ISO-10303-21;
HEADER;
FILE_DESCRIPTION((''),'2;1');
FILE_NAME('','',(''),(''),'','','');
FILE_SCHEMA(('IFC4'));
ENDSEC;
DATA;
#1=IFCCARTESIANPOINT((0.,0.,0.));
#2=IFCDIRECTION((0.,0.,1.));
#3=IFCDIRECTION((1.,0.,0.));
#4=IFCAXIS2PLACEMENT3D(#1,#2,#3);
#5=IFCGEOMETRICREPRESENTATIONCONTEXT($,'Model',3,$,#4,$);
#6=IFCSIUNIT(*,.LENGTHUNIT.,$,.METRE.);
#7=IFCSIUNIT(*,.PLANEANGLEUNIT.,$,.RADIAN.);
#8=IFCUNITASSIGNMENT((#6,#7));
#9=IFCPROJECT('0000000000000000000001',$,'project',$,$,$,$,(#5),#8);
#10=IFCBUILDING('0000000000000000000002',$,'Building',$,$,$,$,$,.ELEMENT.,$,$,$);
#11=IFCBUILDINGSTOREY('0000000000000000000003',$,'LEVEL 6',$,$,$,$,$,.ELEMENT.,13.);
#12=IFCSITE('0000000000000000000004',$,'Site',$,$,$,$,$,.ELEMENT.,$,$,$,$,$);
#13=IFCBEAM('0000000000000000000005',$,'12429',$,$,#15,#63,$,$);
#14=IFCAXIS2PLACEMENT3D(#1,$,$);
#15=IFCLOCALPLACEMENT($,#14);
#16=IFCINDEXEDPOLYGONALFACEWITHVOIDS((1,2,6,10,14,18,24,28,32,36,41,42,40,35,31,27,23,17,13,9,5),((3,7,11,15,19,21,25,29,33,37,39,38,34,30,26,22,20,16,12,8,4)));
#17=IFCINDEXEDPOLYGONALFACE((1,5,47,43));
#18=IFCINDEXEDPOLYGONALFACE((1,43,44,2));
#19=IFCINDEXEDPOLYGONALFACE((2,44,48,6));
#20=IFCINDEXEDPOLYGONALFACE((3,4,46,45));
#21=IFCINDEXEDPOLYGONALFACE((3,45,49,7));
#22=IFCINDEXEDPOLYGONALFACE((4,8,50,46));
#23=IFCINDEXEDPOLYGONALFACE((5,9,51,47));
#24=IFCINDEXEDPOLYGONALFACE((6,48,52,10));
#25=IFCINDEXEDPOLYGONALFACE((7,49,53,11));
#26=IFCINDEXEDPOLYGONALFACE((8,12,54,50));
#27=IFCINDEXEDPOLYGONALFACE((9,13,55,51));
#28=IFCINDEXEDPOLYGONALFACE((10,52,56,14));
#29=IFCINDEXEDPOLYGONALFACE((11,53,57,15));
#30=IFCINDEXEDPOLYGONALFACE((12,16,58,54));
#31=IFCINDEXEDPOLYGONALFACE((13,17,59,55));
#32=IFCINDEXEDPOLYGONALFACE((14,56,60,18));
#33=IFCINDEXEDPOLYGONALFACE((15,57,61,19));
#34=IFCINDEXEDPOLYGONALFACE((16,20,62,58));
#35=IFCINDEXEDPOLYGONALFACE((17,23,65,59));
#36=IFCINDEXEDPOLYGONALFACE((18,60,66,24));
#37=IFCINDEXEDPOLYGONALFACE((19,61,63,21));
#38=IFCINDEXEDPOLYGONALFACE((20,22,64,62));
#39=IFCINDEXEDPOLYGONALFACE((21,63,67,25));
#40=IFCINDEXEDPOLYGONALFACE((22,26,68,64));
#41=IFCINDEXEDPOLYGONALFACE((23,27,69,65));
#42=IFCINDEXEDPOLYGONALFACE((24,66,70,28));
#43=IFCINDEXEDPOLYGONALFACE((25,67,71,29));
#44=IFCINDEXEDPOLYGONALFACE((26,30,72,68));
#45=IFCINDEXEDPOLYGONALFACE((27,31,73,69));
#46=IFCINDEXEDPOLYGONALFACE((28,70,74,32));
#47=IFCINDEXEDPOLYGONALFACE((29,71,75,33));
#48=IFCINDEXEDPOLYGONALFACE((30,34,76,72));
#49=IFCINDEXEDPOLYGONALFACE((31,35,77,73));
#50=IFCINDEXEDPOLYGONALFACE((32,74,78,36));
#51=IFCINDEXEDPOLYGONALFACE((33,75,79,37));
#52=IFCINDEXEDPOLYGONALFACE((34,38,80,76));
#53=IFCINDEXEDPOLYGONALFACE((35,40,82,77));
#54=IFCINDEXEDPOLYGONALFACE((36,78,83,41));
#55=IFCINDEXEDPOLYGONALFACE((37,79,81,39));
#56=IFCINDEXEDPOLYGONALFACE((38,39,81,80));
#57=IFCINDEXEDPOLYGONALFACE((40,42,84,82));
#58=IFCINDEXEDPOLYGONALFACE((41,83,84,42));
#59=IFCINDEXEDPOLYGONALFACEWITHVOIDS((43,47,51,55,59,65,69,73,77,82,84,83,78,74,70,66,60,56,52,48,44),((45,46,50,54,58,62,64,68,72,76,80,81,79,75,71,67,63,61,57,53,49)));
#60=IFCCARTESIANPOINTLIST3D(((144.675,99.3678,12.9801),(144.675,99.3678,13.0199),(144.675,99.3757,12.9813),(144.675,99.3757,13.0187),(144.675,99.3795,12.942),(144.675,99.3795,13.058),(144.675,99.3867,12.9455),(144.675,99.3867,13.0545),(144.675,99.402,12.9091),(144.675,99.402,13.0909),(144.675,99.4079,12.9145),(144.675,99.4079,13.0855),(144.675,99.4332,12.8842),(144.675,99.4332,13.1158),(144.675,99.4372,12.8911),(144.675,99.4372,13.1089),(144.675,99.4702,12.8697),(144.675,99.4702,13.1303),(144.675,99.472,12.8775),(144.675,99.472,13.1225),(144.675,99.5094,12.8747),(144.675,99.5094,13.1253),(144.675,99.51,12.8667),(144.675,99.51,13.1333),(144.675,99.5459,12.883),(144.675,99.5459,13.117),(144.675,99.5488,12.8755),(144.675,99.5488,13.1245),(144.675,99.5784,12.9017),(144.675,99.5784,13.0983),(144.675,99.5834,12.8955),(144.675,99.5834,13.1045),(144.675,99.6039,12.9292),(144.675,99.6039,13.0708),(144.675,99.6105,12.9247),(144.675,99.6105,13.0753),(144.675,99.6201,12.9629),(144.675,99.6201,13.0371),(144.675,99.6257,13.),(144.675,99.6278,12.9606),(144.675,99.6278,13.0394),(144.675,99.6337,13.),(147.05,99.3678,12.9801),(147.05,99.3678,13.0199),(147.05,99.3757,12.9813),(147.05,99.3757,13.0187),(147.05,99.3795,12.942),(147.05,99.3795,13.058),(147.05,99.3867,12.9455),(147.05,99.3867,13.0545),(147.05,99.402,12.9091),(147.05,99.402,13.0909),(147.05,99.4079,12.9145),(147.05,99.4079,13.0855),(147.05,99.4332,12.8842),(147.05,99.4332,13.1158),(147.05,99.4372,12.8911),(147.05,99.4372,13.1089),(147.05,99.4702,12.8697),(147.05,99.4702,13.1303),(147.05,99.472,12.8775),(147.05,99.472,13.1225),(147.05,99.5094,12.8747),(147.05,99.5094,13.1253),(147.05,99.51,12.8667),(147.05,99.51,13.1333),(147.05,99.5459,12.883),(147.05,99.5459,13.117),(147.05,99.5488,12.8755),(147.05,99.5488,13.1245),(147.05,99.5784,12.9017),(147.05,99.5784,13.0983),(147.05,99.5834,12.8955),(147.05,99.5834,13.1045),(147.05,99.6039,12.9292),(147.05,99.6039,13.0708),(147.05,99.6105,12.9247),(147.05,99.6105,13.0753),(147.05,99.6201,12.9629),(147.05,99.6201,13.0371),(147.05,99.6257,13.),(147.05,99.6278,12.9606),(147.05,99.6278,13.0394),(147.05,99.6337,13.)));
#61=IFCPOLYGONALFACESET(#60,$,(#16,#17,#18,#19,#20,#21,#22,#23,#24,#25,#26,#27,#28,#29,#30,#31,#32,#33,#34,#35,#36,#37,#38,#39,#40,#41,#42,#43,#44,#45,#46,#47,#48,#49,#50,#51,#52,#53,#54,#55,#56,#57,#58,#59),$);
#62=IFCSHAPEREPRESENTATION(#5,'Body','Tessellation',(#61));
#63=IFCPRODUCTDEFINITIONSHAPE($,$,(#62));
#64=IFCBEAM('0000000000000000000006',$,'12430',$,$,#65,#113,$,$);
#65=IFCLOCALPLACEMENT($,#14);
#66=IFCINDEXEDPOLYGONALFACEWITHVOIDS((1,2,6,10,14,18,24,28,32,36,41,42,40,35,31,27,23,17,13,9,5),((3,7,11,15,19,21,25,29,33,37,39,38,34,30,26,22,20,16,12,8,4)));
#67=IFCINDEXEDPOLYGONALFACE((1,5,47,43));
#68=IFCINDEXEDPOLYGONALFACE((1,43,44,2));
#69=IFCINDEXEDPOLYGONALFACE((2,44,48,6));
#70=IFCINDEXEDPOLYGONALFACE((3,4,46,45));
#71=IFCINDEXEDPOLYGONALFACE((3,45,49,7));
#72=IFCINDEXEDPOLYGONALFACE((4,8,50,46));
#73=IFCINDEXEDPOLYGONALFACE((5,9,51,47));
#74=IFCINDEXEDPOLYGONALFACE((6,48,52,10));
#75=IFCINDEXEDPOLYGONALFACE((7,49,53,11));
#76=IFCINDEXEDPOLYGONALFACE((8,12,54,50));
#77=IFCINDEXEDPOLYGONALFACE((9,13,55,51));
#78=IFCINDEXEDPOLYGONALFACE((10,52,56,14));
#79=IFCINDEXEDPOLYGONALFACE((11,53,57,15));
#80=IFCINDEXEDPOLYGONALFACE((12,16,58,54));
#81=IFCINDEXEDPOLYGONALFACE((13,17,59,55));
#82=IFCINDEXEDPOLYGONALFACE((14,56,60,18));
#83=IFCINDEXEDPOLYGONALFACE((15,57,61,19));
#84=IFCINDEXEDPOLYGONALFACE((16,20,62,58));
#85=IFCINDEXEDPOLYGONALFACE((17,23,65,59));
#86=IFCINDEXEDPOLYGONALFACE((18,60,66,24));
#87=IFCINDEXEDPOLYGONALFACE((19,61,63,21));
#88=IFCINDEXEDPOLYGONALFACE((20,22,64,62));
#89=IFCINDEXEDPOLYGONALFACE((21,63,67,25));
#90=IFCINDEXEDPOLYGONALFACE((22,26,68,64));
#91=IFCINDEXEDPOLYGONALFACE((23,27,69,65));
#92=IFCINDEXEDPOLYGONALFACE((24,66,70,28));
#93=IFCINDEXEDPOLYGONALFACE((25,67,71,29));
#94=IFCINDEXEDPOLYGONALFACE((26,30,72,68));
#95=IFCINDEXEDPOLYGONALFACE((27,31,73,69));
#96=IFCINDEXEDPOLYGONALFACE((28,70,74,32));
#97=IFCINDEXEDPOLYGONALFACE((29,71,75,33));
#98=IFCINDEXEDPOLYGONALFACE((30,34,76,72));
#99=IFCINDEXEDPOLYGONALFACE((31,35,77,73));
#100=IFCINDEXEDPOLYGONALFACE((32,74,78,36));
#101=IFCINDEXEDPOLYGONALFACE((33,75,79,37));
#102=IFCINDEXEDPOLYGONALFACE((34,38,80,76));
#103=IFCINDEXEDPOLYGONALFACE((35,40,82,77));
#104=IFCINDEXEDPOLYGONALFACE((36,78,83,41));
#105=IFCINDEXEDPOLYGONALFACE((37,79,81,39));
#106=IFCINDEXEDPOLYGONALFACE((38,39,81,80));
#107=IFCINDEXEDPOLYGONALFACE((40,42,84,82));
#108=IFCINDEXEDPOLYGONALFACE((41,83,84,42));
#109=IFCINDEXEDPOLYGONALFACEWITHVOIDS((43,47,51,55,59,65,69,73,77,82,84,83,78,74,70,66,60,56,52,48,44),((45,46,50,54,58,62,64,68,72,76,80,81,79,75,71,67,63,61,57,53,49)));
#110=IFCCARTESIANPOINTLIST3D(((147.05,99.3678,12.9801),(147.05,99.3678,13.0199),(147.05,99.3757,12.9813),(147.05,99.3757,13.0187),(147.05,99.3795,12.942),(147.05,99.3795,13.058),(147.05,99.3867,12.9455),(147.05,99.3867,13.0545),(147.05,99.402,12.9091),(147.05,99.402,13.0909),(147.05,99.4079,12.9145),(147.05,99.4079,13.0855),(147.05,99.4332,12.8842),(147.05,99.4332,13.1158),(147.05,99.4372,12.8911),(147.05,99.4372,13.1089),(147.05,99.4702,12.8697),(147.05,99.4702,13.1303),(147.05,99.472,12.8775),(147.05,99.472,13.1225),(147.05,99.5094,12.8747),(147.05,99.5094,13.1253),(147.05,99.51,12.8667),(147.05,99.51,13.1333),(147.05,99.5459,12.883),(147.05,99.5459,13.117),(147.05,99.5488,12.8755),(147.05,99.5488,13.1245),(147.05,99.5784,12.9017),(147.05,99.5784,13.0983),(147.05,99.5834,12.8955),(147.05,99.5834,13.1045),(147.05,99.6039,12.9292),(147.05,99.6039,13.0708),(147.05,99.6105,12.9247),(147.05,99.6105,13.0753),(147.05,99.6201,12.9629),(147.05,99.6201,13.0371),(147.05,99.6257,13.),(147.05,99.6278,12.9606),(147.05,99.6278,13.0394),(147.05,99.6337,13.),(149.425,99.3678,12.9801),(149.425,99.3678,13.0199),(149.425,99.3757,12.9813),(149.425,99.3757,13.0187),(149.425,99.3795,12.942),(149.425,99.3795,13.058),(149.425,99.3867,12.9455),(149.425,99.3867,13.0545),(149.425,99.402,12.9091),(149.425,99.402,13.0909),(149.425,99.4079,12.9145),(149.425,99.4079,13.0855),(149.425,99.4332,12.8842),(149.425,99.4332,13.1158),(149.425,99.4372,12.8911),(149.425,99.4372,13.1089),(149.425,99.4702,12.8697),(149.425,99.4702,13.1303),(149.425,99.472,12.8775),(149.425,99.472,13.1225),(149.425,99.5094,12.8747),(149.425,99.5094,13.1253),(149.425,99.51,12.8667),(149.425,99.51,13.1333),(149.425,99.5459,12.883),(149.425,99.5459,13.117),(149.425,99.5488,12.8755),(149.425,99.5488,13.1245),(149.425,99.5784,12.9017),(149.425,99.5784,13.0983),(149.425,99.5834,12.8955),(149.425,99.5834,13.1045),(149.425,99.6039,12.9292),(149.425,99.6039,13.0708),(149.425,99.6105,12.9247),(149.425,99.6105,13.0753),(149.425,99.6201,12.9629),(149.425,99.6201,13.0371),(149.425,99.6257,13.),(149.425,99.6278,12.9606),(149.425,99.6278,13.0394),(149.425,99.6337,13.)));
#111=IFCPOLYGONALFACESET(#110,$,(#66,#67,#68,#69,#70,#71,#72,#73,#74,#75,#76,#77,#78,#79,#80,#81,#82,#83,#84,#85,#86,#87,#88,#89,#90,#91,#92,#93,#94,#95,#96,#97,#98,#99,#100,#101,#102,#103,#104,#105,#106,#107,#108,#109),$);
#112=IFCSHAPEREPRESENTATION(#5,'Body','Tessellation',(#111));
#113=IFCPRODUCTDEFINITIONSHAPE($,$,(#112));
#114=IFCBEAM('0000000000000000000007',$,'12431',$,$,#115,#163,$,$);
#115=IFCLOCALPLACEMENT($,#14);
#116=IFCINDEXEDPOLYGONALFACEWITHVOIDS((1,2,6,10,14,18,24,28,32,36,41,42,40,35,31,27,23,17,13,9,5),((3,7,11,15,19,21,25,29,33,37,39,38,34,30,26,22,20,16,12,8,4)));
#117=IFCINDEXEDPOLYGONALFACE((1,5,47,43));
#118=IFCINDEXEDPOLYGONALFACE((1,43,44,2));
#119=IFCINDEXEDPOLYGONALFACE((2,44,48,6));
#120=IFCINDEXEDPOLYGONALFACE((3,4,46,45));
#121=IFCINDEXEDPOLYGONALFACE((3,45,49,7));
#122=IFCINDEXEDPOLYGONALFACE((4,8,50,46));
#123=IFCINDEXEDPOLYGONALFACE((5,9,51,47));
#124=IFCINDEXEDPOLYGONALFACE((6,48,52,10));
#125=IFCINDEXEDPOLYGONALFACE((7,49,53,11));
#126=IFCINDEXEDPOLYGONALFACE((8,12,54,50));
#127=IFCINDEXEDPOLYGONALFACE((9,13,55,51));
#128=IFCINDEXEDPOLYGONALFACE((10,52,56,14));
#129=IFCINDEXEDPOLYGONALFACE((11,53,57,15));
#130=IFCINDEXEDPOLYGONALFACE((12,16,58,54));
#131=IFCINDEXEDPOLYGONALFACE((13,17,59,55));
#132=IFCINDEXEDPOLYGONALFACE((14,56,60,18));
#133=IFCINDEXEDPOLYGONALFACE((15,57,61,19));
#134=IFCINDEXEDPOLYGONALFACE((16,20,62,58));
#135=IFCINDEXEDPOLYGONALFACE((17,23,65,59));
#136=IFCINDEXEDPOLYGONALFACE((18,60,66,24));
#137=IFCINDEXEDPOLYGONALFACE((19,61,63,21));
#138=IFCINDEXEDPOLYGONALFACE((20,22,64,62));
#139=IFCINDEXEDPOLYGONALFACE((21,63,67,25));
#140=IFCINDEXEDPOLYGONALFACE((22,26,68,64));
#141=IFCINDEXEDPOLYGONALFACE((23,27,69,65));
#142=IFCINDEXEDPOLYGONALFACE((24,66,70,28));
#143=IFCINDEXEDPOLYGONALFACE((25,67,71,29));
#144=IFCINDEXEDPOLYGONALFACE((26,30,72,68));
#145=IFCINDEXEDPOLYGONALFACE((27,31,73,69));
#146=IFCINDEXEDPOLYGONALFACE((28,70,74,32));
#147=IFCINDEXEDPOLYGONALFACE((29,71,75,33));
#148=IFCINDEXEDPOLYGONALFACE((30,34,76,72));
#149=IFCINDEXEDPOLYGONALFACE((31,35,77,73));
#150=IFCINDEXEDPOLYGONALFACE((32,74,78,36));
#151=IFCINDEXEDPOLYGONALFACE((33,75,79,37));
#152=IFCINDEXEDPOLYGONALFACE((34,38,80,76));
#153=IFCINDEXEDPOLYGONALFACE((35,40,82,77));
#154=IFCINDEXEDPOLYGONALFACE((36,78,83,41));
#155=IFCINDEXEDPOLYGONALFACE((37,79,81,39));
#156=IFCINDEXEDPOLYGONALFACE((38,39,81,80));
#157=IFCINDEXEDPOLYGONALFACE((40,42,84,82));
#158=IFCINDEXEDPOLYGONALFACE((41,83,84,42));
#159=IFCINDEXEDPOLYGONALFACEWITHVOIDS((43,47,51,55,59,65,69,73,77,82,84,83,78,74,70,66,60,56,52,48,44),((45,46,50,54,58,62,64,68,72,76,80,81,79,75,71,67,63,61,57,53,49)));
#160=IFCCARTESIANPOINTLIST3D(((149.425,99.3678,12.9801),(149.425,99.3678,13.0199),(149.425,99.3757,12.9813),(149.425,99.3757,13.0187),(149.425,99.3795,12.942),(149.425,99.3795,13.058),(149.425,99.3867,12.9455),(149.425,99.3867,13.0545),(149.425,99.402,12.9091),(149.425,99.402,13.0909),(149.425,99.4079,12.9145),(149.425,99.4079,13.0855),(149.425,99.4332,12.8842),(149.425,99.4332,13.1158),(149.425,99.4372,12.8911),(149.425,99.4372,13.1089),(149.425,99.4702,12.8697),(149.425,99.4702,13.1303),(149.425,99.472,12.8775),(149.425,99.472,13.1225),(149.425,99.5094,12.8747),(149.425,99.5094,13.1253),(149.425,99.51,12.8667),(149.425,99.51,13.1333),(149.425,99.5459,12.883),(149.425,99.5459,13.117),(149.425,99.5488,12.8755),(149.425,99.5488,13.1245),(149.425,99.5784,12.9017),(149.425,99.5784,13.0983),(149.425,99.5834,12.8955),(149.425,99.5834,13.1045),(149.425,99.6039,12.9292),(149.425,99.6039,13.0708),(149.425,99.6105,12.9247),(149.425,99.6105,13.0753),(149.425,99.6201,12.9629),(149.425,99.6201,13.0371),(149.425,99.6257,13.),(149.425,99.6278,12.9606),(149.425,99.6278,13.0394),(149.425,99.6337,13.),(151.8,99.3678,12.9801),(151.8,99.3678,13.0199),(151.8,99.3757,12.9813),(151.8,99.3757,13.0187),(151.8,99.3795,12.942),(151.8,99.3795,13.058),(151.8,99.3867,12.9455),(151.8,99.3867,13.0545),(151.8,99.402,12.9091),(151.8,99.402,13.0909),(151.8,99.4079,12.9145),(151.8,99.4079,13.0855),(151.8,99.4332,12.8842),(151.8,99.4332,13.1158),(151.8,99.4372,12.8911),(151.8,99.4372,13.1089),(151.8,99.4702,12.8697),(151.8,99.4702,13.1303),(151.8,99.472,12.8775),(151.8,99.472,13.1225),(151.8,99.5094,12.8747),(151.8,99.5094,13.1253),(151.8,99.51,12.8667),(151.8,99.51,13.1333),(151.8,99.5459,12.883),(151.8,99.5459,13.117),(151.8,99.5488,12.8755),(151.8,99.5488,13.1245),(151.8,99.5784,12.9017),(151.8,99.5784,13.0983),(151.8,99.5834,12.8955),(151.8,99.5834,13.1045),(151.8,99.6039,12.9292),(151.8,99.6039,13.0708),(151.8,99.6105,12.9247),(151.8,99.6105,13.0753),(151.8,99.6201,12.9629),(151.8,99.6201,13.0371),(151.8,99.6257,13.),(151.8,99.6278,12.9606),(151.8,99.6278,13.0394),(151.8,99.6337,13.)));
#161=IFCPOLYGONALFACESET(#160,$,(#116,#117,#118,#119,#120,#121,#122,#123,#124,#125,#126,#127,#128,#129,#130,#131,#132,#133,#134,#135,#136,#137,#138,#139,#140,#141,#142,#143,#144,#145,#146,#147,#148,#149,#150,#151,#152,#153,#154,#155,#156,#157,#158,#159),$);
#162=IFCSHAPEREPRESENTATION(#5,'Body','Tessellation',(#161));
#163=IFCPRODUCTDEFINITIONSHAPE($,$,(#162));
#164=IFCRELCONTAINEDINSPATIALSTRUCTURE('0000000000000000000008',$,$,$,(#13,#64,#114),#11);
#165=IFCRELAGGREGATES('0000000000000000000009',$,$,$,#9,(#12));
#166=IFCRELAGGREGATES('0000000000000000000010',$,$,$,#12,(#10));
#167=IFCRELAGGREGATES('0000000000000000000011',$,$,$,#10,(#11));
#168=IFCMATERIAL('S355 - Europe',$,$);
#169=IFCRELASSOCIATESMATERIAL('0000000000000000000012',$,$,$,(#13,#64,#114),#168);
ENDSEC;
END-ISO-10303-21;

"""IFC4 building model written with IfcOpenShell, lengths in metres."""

from ifc_helpers import new_model, si_unit, frame, origin_with_axes, origin_2d_with_axis, place, context, project, spatial, hollow_circle, extrude, material, material_profile, profile_set, profile_usage, element, save


model = new_model("IFC4")

# Units and contexts
model_context = context("Model", 3, world=origin_with_axes())
ifc_project = project(units=[si_unit("LENGTHUNIT", "METRE"), si_unit("PLANEANGLEUNIT", "RADIAN")], contexts=[model_context])

# Site, building, storey
site = spatial("IfcSite", under=ifc_project, Name="Site", CompositionType="ELEMENT")
building = spatial("IfcBuilding", under=site, Name="Building", CompositionType="ELEMENT")
storey = spatial("IfcBuildingStorey", under=building, Name="LEVEL 6", CompositionType="ELEMENT", Elevation=13.0)

# Shared definitions
ifc_material = material(Name="S355 - Europe")

# Beams
ifc_material_profile_1 = material_profile(ifc_material, hollow_circle(Radius=0.1337, WallThickness=0.008, at=origin_2d_with_axis()))
ifc_profile_set_1 = profile_set([ifc_material_profile_1])
ifc_profile_usage_1 = profile_usage(ifc_profile_set_1, cardinal=10)
beam_1_placement = place(None, frame((144.675, 99.5, 13.0), z_axis=(1.0, 0.0, 0.0), x_axis=(0.0, 1.0, 0.0)))
element("IfcBeam", 1, at=beam_1_placement, inside=storey, material=ifc_profile_usage_1, Name="12429", context=model_context, shape_type="SweptSolid", body=[
    extrude(hollow_circle(Radius=0.1337, WallThickness=0.008, at=origin_2d_with_axis()), origin_with_axes(), (0.0, 0.0, 1.0), 2.375),
])
ifc_material_profile_2 = material_profile(ifc_material, hollow_circle(Radius=0.1337, WallThickness=0.008, at=origin_2d_with_axis()))
ifc_profile_set_2 = profile_set([ifc_material_profile_2])
ifc_profile_usage_2 = profile_usage(ifc_profile_set_2, cardinal=10)
beam_2_placement = place(None, frame((147.05, 99.5, 13.0), z_axis=(1.0, 0.0, 0.0), x_axis=(0.0, 1.0, 0.0)))
element("IfcBeam", 2, at=beam_2_placement, inside=storey, material=ifc_profile_usage_2, Name="12430", context=model_context, shape_type="SweptSolid", body=[
    extrude(hollow_circle(Radius=0.1337, WallThickness=0.008, at=origin_2d_with_axis()), origin_with_axes(), (0.0, 0.0, 1.0), 2.375),
])
ifc_material_profile_3 = material_profile(ifc_material, hollow_circle(Radius=0.1337, WallThickness=0.008, at=origin_2d_with_axis()))
ifc_profile_set_3 = profile_set([ifc_material_profile_3])
ifc_profile_usage_3 = profile_usage(ifc_profile_set_3, cardinal=10)
beam_3_placement = place(None, frame((149.425, 99.5, 13.0), z_axis=(1.0, 0.0, 0.0), x_axis=(0.0, 1.0, 0.0)))
element("IfcBeam", 3, at=beam_3_placement, inside=storey, material=ifc_profile_usage_3, Name="12431", context=model_context, shape_type="SweptSolid", body=[
    extrude(hollow_circle(Radius=0.1337, WallThickness=0.008, at=origin_2d_with_axis()), origin_with_axes(), (0.0, 0.0, 1.0), 2.375),
])

save(model, "model.ifc")
